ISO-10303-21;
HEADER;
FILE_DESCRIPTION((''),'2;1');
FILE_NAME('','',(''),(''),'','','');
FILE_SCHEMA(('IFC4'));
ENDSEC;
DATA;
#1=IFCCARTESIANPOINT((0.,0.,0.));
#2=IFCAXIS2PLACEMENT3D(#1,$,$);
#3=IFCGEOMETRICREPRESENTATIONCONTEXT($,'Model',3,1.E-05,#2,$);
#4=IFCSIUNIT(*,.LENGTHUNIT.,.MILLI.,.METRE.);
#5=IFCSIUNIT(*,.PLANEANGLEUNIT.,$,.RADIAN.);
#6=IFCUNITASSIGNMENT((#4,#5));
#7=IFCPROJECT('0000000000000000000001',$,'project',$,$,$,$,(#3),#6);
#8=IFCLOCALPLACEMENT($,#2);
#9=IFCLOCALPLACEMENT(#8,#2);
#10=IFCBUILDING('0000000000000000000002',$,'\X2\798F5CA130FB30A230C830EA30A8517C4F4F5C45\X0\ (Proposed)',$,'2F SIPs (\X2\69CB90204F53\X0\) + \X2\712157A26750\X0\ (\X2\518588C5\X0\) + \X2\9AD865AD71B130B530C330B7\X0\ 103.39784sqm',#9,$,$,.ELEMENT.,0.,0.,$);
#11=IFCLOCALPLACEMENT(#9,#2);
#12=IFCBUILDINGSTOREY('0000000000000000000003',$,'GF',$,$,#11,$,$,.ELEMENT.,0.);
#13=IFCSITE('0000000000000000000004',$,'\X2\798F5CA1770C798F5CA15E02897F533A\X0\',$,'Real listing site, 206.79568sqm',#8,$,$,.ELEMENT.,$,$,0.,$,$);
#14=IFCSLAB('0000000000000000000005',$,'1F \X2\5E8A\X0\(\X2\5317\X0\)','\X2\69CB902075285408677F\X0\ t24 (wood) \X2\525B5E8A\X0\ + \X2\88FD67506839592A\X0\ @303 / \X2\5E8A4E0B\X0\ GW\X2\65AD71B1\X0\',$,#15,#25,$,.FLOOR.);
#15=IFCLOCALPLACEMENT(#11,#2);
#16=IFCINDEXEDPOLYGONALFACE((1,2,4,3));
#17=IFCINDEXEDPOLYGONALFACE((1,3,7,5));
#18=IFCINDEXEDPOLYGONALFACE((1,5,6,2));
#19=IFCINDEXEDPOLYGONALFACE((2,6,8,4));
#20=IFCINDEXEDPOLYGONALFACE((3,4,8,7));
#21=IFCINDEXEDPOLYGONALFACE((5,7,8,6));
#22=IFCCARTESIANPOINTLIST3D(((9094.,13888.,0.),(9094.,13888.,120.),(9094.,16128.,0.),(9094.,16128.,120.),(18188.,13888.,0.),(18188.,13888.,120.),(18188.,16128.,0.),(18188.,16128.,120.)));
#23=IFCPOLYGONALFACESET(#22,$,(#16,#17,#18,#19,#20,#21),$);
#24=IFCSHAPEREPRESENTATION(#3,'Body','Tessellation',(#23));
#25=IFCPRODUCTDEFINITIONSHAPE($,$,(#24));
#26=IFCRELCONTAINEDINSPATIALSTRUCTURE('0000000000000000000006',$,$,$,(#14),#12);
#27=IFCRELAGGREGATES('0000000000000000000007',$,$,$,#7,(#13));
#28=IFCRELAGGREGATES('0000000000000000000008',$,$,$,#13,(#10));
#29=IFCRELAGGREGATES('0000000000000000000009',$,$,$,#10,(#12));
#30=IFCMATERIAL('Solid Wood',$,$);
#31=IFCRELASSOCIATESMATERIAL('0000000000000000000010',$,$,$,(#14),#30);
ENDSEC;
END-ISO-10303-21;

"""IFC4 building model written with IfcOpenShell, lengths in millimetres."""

from ifc_helpers import new_model, si_unit, frame, frame_2d, origin, place, context, project, spatial, rectangle, extrude, material, element, save


model = new_model("IFC4")

# Units and contexts
model_context = context("Model", 3, precision=1e-05, world=origin())
ifc_project = project(units=[si_unit("LENGTHUNIT", "METRE", prefix="MILLI"), si_unit("PLANEANGLEUNIT", "RADIAN")], contexts=[model_context])

# Site, building, storey
site_placement = place(None, origin())
site = spatial("IfcSite", under=ifc_project, at=site_placement, Name="福岡県福岡市西区", ObjectType="Real listing site, 206.79568sqm", CompositionType="ELEMENT", RefElevation=0.0)
building_placement = place(site_placement, origin())
building = spatial("IfcBuilding", under=site, at=building_placement, Name="福岡・アトリエ兼住居 (Proposed)", ObjectType="2F SIPs (構造体) + 無垢材 (内装) + 高断熱サッシ 103.39784sqm", CompositionType="ELEMENT", ElevationOfRefHeight=0.0, ElevationOfTerrain=0.0)
storey_placement = place(building_placement, origin())
storey = spatial("IfcBuildingStorey", under=building, at=storey_placement, Name="GF", CompositionType="ELEMENT", Elevation=0.0)

# Slab
ifc_material_1 = material(Name="Solid Wood")
slab_1_placement = place(storey_placement, frame((4547.0, 6944.0, 0.0)))
element("IfcSlab", 1, at=slab_1_placement, inside=storey, material=ifc_material_1, Name="1F 床(北)", Description="構造用合板 t24 (wood) 剛床 + 製材根太 @303 / 床下 GW断熱", PredefinedType="FLOOR", context=model_context, shape_type="SweptSolid", body=[
    extrude(rectangle(XDim=9094.0, YDim=2240.0, at=frame_2d((4547.0, 1120.0))), frame((4547.0, 6944.0, 0.0)), (0.0, 0.0, 1.0), 120.0),
])

save(model, "model.ifc")
